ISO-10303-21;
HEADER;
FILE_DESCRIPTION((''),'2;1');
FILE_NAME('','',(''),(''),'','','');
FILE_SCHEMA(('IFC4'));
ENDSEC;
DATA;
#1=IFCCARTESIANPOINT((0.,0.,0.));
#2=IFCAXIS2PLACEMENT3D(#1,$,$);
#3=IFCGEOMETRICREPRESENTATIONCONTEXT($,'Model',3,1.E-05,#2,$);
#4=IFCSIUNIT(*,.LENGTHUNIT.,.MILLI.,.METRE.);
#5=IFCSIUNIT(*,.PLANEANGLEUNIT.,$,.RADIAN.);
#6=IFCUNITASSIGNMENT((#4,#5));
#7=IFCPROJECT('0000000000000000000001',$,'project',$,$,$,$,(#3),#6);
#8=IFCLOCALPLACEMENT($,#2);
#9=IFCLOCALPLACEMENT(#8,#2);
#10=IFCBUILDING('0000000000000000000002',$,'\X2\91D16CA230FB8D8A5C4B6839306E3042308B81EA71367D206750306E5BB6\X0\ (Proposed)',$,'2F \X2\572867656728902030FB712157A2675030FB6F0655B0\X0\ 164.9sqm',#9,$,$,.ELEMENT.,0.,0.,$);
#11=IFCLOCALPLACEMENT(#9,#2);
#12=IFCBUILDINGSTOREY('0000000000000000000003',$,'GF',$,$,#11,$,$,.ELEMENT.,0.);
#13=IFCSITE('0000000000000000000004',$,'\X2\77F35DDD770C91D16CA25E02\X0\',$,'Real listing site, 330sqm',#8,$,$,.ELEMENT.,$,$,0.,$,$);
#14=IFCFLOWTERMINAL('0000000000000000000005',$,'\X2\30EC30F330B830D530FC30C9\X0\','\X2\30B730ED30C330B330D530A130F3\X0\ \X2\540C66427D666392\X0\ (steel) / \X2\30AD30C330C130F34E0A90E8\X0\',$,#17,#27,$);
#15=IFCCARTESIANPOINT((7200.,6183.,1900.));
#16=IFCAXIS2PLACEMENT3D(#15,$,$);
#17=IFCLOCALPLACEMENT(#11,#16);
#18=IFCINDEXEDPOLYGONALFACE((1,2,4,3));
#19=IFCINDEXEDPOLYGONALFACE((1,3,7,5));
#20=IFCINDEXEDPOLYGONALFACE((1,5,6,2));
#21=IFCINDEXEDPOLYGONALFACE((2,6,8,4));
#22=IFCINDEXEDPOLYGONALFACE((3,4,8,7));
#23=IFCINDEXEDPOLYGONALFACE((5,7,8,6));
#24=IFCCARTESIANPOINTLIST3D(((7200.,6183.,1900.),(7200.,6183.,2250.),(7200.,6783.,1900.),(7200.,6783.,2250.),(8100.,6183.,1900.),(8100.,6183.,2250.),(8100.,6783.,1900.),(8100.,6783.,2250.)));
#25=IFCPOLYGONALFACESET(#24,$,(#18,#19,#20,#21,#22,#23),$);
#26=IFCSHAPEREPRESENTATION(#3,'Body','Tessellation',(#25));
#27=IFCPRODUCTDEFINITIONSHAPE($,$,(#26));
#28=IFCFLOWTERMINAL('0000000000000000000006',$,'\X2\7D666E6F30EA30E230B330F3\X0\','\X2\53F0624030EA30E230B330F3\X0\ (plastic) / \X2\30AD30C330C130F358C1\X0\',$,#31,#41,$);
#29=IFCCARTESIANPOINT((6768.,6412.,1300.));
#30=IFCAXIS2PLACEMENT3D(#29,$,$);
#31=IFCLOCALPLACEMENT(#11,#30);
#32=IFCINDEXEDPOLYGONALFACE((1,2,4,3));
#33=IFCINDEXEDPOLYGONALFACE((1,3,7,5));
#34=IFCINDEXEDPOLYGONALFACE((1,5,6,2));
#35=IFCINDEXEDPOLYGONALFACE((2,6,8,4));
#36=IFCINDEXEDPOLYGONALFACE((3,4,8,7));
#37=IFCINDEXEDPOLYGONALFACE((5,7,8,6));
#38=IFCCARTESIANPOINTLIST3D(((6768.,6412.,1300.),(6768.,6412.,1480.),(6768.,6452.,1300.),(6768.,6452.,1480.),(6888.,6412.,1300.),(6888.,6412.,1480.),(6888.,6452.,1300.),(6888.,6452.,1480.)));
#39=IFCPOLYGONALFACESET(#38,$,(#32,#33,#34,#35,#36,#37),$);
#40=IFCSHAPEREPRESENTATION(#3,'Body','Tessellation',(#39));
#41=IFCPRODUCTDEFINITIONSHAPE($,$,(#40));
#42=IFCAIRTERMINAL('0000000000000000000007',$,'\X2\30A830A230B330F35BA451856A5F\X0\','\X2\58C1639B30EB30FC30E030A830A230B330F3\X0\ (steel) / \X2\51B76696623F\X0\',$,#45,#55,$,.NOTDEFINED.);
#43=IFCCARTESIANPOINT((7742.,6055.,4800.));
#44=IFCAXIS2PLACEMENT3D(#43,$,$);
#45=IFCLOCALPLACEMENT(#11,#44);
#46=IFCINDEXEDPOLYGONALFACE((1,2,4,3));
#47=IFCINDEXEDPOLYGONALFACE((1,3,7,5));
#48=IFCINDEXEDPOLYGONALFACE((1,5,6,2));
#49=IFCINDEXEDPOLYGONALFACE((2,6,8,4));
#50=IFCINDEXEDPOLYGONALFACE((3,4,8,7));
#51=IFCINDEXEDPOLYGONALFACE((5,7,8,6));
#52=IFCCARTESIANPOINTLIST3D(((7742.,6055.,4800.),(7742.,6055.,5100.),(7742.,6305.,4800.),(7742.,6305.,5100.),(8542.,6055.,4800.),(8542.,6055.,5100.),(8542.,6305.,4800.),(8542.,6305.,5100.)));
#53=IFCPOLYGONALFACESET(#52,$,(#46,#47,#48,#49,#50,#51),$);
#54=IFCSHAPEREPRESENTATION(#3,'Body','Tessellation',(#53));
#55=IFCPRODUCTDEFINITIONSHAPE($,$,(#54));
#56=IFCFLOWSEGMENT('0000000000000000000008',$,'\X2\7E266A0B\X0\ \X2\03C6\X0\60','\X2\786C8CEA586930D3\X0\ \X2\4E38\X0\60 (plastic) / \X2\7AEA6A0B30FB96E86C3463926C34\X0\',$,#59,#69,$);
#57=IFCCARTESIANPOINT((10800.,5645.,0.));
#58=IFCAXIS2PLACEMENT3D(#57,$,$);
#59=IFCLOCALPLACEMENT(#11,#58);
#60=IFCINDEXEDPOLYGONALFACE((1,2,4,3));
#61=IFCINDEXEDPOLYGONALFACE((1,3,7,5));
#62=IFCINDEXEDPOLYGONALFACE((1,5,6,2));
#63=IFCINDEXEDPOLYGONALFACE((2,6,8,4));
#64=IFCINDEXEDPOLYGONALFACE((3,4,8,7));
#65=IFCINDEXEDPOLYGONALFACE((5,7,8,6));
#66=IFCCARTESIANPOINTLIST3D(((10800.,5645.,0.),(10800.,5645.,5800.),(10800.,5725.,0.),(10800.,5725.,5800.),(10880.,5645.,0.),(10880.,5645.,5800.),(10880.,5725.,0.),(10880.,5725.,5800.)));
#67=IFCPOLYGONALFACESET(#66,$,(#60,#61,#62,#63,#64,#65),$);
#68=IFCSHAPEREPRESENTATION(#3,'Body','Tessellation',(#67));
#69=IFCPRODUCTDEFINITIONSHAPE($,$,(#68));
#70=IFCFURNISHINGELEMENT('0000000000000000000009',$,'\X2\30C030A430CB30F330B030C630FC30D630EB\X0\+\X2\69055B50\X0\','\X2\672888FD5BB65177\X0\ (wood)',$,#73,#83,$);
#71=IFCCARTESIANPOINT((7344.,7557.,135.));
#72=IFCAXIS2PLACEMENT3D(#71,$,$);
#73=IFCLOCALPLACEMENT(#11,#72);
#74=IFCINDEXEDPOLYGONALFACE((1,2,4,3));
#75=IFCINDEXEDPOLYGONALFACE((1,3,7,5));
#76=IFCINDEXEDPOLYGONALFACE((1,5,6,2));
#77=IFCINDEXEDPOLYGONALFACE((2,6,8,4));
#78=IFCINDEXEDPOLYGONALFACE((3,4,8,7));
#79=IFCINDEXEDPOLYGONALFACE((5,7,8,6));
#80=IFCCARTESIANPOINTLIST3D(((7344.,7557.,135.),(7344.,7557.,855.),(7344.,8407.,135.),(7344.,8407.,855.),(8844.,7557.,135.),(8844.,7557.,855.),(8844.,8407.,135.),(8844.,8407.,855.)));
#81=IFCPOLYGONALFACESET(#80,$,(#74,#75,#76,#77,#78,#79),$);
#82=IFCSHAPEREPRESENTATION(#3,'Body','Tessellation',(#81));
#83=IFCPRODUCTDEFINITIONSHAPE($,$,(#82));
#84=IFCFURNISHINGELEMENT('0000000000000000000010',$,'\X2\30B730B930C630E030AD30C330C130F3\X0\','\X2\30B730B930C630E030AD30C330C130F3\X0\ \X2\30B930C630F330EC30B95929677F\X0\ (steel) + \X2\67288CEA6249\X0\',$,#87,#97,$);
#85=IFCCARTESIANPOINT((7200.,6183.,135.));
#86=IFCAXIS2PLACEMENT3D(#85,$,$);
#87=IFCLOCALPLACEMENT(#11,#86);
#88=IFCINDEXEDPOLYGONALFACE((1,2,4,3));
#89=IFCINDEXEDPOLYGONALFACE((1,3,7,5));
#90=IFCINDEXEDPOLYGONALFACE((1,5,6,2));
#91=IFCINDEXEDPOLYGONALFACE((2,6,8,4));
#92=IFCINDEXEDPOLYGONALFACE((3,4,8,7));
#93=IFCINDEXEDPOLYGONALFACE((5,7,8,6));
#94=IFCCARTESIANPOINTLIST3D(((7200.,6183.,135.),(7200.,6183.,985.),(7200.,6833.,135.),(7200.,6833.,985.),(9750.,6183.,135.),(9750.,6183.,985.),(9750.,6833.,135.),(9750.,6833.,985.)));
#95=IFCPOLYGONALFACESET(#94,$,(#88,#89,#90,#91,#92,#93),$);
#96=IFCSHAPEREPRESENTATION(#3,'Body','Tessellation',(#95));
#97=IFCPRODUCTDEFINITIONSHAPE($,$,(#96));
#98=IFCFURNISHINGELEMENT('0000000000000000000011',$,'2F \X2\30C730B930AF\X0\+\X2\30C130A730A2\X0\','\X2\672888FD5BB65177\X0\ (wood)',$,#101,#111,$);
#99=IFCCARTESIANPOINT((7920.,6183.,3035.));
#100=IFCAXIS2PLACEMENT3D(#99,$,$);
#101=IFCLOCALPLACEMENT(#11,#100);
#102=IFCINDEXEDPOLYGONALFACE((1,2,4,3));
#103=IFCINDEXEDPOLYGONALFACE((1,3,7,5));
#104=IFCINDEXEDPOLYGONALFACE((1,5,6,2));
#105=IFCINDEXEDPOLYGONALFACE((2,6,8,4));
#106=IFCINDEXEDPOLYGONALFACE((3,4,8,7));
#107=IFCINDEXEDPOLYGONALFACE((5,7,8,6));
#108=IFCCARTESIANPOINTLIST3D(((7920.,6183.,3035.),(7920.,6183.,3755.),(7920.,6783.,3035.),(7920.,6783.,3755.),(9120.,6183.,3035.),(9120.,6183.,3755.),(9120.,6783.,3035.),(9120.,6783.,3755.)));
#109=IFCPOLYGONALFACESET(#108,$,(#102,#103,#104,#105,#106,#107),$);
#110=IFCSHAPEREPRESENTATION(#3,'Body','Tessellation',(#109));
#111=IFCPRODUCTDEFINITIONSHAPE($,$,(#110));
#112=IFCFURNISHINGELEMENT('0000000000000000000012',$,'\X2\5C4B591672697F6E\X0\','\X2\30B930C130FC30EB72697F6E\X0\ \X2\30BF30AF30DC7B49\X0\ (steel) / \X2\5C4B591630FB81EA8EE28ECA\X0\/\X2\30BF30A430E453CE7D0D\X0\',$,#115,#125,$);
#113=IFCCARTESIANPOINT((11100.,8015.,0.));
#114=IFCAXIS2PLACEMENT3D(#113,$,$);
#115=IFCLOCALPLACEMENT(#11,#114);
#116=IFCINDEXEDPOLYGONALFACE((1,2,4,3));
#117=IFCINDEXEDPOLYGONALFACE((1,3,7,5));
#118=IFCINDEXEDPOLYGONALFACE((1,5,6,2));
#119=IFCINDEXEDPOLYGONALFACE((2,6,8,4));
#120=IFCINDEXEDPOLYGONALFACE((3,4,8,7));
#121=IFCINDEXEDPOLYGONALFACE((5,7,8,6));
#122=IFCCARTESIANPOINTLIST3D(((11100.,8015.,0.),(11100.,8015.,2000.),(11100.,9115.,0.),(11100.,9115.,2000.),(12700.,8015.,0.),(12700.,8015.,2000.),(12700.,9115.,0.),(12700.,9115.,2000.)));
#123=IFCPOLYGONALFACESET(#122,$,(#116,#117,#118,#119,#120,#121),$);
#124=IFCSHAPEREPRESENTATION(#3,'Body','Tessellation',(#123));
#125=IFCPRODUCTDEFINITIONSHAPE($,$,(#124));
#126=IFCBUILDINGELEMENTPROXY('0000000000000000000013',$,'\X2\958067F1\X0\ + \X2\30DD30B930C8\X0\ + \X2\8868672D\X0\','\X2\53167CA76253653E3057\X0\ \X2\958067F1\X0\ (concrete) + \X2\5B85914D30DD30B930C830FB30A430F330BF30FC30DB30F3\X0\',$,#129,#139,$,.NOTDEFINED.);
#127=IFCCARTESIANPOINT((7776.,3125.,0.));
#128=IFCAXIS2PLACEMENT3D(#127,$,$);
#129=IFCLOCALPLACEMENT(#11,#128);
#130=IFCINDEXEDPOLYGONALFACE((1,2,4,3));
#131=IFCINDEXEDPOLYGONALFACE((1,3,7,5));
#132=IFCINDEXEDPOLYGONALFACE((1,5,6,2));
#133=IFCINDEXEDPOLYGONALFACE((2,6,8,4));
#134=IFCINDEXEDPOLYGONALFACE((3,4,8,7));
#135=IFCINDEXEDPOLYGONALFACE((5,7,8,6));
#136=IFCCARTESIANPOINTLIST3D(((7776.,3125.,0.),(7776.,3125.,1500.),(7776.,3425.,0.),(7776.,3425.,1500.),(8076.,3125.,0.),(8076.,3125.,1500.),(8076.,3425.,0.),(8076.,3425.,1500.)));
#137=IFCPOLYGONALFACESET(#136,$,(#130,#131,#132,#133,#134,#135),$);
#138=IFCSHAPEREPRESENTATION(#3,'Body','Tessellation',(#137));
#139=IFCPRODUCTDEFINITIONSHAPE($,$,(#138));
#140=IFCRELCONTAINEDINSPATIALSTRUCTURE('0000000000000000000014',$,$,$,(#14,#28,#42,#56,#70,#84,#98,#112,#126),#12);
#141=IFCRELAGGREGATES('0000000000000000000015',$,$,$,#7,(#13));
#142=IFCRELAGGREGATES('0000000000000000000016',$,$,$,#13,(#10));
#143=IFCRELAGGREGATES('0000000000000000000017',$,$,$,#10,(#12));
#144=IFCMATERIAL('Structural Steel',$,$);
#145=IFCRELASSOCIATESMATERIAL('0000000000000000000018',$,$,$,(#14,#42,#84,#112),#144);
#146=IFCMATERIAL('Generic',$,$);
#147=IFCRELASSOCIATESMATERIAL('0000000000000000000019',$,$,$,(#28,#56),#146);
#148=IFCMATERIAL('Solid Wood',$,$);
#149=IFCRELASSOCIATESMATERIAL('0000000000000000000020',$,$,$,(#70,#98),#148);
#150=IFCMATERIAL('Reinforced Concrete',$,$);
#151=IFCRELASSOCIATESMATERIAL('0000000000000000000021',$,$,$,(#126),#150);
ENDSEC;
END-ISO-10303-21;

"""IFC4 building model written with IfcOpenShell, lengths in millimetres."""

from ifc_helpers import new_model, si_unit, frame, frame_2d, origin, place, context, project, spatial, rectangle, extrude, material, element, save


model = new_model("IFC4")

# Units and contexts
model_context = context("Model", 3, precision=1e-05, world=origin())
ifc_project = project(units=[si_unit("LENGTHUNIT", "METRE", prefix="MILLI"), si_unit("PLANEANGLEUNIT", "RADIAN")], contexts=[model_context])

# Site, building, storey
site_placement = place(None, origin())
site = spatial("IfcSite", under=ifc_project, at=site_placement, Name="石川県金沢市", ObjectType="Real listing site, 330sqm", CompositionType="ELEMENT", RefElevation=0.0)
building_placement = place(site_placement, origin())
building = spatial("IfcBuilding", under=site, at=building_placement, Name="金沢・越屋根のある自然素材の家 (Proposed)", ObjectType="2F 在来木造・無垢材・漆喰 164.9sqm", CompositionType="ELEMENT", ElevationOfRefHeight=0.0, ElevationOfTerrain=0.0)
storey_placement = place(building_placement, origin())
storey = spatial("IfcBuildingStorey", under=building, at=storey_placement, Name="GF", CompositionType="ELEMENT", Elevation=0.0)

# Shared definitions
ifc_material_1 = material(Name="Solid Wood")

# Shared definitions
ifc_material_2 = material(Name="Reinforced Concrete")

# Shared definitions
ifc_material_3 = material(Name="Structural Steel")

# Flow terminals
flow_terminal_1_placement = place(storey_placement, frame((7200.0, 6183.0, 1900.0)))
element("IfcFlowTerminal", 1, at=flow_terminal_1_placement, inside=storey, material=ifc_material_3, Name="レンジフード", Description="シロッコファン 同時給排 (steel) / キッチン上部", context=model_context, shape_type="SweptSolid", body=[
    extrude(rectangle(XDim=900.0, YDim=600.0, at=frame_2d((450.0, 300.0))), frame((7200.0, 6183.0, 1900.0)), (0.0, 0.0, 1.0), 350.0),
])
ifc_material_4 = material(Name="Generic")
flow_terminal_2_placement = place(storey_placement, frame((6768.0, 6412.0, 1300.0)))
element("IfcFlowTerminal", 2, at=flow_terminal_2_placement, inside=storey, material=ifc_material_4, Name="給湯リモコン", Description="台所リモコン (plastic) / キッチン壁", context=model_context, shape_type="SweptSolid", body=[
    extrude(rectangle(XDim=120.0, YDim=40.0, at=frame_2d((60.0, 20.0))), frame((6768.0, 6412.0, 1300.0)), (0.0, 0.0, 1.0), 180.0),
])

# Air terminal
air_terminal_placement = place(storey_placement, frame((7742.0, 6055.0, 4800.0)))
element("IfcAirTerminal", 3, at=air_terminal_placement, inside=storey, material=ifc_material_3, Name="エアコン室内機", Description="壁掛ルームエアコン (steel) / 冷暖房", PredefinedType="NOTDEFINED", context=model_context, shape_type="SweptSolid", body=[
    extrude(rectangle(XDim=800.0, YDim=250.0, at=frame_2d((400.0, 125.0))), frame((7742.0, 6055.0, 4800.0)), (0.0, 0.0, 1.0), 300.0),
])

# Flow segment
flow_segment_placement = place(storey_placement, frame((10800.0, 5645.0, 0.0)))
element("IfcFlowSegment", 4, at=flow_segment_placement, inside=storey, material=ifc_material_4, Name="縦樋 φ60", Description="硬質塩ビ 丸60 (plastic) / 竪樋・雨水排水", context=model_context, shape_type="SweptSolid", body=[
    extrude(rectangle(XDim=80.0, YDim=80.0, at=frame_2d((40.0, 40.0))), frame((10800.0, 5645.0, 0.0)), (0.0, 0.0, 1.0), 5800.0),
])

# Furnishing elements
furnishing_1_placement = place(storey_placement, frame((7344.0, 7557.0, 135.0)))
element("IfcFurnishingElement", 5, at=furnishing_1_placement, inside=storey, material=ifc_material_1, Name="ダイニングテーブル+椅子", Description="木製家具 (wood)", context=model_context, shape_type="SweptSolid", body=[
    extrude(rectangle(XDim=1500.0, YDim=850.0, at=frame_2d((750.0, 425.0))), frame((7344.0, 7557.0, 135.0)), (0.0, 0.0, 1.0), 720.0),
])
furnishing_2_placement = place(storey_placement, frame((7200.0, 6183.0, 135.0)))
element("IfcFurnishingElement", 6, at=furnishing_2_placement, inside=storey, material=ifc_material_3, Name="システムキッチン", Description="システムキッチン ステンレス天板 (steel) + 木質扉", context=model_context, shape_type="SweptSolid", body=[
    extrude(rectangle(XDim=2550.0, YDim=650.0, at=frame_2d((1275.0, 325.0))), frame((7200.0, 6183.0, 135.0)), (0.0, 0.0, 1.0), 850.0),
])
furnishing_3_placement = place(storey_placement, frame((7920.0, 6183.0, 3035.0)))
element("IfcFurnishingElement", 7, at=furnishing_3_placement, inside=storey, material=ifc_material_1, Name="2F デスク+チェア", Description="木製家具 (wood)", context=model_context, shape_type="SweptSolid", body=[
    extrude(rectangle(XDim=1200.0, YDim=600.0, at=frame_2d((600.0, 300.0))), frame((7920.0, 6183.0, 3035.0)), (0.0, 0.0, 1.0), 720.0),
])
furnishing_4_placement = place(storey_placement, frame((11100.0, 8015.0, 0.0)))
element("IfcFurnishingElement", 8, at=furnishing_4_placement, inside=storey, material=ifc_material_3, Name="屋外物置", Description="スチール物置 タクボ等 (steel) / 屋外・自転車/タイヤ収納", context=model_context, shape_type="SweptSolid", body=[
    extrude(rectangle(XDim=1600.0, YDim=1100.0, at=frame_2d((800.0, 550.0))), frame((11100.0, 8015.0, 0.0)), (0.0, 0.0, 1.0), 2000.0),
])

# Building element proxy
proxy_placement = place(storey_placement, frame((7776.0, 3125.0, 0.0)))
element("IfcBuildingElementProxy", 9, at=proxy_placement, inside=storey, material=ifc_material_2, Name="門柱 + ポスト + 表札", Description="化粧打放し 門柱 (concrete) + 宅配ポスト・インターホン", PredefinedType="NOTDEFINED", context=model_context, shape_type="SweptSolid", body=[
    extrude(rectangle(XDim=300.0, YDim=300.0, at=frame_2d((150.0, 150.0))), frame((7776.0, 3125.0, 0.0)), (0.0, 0.0, 1.0), 1500.0),
])

save(model, "model.ifc")
